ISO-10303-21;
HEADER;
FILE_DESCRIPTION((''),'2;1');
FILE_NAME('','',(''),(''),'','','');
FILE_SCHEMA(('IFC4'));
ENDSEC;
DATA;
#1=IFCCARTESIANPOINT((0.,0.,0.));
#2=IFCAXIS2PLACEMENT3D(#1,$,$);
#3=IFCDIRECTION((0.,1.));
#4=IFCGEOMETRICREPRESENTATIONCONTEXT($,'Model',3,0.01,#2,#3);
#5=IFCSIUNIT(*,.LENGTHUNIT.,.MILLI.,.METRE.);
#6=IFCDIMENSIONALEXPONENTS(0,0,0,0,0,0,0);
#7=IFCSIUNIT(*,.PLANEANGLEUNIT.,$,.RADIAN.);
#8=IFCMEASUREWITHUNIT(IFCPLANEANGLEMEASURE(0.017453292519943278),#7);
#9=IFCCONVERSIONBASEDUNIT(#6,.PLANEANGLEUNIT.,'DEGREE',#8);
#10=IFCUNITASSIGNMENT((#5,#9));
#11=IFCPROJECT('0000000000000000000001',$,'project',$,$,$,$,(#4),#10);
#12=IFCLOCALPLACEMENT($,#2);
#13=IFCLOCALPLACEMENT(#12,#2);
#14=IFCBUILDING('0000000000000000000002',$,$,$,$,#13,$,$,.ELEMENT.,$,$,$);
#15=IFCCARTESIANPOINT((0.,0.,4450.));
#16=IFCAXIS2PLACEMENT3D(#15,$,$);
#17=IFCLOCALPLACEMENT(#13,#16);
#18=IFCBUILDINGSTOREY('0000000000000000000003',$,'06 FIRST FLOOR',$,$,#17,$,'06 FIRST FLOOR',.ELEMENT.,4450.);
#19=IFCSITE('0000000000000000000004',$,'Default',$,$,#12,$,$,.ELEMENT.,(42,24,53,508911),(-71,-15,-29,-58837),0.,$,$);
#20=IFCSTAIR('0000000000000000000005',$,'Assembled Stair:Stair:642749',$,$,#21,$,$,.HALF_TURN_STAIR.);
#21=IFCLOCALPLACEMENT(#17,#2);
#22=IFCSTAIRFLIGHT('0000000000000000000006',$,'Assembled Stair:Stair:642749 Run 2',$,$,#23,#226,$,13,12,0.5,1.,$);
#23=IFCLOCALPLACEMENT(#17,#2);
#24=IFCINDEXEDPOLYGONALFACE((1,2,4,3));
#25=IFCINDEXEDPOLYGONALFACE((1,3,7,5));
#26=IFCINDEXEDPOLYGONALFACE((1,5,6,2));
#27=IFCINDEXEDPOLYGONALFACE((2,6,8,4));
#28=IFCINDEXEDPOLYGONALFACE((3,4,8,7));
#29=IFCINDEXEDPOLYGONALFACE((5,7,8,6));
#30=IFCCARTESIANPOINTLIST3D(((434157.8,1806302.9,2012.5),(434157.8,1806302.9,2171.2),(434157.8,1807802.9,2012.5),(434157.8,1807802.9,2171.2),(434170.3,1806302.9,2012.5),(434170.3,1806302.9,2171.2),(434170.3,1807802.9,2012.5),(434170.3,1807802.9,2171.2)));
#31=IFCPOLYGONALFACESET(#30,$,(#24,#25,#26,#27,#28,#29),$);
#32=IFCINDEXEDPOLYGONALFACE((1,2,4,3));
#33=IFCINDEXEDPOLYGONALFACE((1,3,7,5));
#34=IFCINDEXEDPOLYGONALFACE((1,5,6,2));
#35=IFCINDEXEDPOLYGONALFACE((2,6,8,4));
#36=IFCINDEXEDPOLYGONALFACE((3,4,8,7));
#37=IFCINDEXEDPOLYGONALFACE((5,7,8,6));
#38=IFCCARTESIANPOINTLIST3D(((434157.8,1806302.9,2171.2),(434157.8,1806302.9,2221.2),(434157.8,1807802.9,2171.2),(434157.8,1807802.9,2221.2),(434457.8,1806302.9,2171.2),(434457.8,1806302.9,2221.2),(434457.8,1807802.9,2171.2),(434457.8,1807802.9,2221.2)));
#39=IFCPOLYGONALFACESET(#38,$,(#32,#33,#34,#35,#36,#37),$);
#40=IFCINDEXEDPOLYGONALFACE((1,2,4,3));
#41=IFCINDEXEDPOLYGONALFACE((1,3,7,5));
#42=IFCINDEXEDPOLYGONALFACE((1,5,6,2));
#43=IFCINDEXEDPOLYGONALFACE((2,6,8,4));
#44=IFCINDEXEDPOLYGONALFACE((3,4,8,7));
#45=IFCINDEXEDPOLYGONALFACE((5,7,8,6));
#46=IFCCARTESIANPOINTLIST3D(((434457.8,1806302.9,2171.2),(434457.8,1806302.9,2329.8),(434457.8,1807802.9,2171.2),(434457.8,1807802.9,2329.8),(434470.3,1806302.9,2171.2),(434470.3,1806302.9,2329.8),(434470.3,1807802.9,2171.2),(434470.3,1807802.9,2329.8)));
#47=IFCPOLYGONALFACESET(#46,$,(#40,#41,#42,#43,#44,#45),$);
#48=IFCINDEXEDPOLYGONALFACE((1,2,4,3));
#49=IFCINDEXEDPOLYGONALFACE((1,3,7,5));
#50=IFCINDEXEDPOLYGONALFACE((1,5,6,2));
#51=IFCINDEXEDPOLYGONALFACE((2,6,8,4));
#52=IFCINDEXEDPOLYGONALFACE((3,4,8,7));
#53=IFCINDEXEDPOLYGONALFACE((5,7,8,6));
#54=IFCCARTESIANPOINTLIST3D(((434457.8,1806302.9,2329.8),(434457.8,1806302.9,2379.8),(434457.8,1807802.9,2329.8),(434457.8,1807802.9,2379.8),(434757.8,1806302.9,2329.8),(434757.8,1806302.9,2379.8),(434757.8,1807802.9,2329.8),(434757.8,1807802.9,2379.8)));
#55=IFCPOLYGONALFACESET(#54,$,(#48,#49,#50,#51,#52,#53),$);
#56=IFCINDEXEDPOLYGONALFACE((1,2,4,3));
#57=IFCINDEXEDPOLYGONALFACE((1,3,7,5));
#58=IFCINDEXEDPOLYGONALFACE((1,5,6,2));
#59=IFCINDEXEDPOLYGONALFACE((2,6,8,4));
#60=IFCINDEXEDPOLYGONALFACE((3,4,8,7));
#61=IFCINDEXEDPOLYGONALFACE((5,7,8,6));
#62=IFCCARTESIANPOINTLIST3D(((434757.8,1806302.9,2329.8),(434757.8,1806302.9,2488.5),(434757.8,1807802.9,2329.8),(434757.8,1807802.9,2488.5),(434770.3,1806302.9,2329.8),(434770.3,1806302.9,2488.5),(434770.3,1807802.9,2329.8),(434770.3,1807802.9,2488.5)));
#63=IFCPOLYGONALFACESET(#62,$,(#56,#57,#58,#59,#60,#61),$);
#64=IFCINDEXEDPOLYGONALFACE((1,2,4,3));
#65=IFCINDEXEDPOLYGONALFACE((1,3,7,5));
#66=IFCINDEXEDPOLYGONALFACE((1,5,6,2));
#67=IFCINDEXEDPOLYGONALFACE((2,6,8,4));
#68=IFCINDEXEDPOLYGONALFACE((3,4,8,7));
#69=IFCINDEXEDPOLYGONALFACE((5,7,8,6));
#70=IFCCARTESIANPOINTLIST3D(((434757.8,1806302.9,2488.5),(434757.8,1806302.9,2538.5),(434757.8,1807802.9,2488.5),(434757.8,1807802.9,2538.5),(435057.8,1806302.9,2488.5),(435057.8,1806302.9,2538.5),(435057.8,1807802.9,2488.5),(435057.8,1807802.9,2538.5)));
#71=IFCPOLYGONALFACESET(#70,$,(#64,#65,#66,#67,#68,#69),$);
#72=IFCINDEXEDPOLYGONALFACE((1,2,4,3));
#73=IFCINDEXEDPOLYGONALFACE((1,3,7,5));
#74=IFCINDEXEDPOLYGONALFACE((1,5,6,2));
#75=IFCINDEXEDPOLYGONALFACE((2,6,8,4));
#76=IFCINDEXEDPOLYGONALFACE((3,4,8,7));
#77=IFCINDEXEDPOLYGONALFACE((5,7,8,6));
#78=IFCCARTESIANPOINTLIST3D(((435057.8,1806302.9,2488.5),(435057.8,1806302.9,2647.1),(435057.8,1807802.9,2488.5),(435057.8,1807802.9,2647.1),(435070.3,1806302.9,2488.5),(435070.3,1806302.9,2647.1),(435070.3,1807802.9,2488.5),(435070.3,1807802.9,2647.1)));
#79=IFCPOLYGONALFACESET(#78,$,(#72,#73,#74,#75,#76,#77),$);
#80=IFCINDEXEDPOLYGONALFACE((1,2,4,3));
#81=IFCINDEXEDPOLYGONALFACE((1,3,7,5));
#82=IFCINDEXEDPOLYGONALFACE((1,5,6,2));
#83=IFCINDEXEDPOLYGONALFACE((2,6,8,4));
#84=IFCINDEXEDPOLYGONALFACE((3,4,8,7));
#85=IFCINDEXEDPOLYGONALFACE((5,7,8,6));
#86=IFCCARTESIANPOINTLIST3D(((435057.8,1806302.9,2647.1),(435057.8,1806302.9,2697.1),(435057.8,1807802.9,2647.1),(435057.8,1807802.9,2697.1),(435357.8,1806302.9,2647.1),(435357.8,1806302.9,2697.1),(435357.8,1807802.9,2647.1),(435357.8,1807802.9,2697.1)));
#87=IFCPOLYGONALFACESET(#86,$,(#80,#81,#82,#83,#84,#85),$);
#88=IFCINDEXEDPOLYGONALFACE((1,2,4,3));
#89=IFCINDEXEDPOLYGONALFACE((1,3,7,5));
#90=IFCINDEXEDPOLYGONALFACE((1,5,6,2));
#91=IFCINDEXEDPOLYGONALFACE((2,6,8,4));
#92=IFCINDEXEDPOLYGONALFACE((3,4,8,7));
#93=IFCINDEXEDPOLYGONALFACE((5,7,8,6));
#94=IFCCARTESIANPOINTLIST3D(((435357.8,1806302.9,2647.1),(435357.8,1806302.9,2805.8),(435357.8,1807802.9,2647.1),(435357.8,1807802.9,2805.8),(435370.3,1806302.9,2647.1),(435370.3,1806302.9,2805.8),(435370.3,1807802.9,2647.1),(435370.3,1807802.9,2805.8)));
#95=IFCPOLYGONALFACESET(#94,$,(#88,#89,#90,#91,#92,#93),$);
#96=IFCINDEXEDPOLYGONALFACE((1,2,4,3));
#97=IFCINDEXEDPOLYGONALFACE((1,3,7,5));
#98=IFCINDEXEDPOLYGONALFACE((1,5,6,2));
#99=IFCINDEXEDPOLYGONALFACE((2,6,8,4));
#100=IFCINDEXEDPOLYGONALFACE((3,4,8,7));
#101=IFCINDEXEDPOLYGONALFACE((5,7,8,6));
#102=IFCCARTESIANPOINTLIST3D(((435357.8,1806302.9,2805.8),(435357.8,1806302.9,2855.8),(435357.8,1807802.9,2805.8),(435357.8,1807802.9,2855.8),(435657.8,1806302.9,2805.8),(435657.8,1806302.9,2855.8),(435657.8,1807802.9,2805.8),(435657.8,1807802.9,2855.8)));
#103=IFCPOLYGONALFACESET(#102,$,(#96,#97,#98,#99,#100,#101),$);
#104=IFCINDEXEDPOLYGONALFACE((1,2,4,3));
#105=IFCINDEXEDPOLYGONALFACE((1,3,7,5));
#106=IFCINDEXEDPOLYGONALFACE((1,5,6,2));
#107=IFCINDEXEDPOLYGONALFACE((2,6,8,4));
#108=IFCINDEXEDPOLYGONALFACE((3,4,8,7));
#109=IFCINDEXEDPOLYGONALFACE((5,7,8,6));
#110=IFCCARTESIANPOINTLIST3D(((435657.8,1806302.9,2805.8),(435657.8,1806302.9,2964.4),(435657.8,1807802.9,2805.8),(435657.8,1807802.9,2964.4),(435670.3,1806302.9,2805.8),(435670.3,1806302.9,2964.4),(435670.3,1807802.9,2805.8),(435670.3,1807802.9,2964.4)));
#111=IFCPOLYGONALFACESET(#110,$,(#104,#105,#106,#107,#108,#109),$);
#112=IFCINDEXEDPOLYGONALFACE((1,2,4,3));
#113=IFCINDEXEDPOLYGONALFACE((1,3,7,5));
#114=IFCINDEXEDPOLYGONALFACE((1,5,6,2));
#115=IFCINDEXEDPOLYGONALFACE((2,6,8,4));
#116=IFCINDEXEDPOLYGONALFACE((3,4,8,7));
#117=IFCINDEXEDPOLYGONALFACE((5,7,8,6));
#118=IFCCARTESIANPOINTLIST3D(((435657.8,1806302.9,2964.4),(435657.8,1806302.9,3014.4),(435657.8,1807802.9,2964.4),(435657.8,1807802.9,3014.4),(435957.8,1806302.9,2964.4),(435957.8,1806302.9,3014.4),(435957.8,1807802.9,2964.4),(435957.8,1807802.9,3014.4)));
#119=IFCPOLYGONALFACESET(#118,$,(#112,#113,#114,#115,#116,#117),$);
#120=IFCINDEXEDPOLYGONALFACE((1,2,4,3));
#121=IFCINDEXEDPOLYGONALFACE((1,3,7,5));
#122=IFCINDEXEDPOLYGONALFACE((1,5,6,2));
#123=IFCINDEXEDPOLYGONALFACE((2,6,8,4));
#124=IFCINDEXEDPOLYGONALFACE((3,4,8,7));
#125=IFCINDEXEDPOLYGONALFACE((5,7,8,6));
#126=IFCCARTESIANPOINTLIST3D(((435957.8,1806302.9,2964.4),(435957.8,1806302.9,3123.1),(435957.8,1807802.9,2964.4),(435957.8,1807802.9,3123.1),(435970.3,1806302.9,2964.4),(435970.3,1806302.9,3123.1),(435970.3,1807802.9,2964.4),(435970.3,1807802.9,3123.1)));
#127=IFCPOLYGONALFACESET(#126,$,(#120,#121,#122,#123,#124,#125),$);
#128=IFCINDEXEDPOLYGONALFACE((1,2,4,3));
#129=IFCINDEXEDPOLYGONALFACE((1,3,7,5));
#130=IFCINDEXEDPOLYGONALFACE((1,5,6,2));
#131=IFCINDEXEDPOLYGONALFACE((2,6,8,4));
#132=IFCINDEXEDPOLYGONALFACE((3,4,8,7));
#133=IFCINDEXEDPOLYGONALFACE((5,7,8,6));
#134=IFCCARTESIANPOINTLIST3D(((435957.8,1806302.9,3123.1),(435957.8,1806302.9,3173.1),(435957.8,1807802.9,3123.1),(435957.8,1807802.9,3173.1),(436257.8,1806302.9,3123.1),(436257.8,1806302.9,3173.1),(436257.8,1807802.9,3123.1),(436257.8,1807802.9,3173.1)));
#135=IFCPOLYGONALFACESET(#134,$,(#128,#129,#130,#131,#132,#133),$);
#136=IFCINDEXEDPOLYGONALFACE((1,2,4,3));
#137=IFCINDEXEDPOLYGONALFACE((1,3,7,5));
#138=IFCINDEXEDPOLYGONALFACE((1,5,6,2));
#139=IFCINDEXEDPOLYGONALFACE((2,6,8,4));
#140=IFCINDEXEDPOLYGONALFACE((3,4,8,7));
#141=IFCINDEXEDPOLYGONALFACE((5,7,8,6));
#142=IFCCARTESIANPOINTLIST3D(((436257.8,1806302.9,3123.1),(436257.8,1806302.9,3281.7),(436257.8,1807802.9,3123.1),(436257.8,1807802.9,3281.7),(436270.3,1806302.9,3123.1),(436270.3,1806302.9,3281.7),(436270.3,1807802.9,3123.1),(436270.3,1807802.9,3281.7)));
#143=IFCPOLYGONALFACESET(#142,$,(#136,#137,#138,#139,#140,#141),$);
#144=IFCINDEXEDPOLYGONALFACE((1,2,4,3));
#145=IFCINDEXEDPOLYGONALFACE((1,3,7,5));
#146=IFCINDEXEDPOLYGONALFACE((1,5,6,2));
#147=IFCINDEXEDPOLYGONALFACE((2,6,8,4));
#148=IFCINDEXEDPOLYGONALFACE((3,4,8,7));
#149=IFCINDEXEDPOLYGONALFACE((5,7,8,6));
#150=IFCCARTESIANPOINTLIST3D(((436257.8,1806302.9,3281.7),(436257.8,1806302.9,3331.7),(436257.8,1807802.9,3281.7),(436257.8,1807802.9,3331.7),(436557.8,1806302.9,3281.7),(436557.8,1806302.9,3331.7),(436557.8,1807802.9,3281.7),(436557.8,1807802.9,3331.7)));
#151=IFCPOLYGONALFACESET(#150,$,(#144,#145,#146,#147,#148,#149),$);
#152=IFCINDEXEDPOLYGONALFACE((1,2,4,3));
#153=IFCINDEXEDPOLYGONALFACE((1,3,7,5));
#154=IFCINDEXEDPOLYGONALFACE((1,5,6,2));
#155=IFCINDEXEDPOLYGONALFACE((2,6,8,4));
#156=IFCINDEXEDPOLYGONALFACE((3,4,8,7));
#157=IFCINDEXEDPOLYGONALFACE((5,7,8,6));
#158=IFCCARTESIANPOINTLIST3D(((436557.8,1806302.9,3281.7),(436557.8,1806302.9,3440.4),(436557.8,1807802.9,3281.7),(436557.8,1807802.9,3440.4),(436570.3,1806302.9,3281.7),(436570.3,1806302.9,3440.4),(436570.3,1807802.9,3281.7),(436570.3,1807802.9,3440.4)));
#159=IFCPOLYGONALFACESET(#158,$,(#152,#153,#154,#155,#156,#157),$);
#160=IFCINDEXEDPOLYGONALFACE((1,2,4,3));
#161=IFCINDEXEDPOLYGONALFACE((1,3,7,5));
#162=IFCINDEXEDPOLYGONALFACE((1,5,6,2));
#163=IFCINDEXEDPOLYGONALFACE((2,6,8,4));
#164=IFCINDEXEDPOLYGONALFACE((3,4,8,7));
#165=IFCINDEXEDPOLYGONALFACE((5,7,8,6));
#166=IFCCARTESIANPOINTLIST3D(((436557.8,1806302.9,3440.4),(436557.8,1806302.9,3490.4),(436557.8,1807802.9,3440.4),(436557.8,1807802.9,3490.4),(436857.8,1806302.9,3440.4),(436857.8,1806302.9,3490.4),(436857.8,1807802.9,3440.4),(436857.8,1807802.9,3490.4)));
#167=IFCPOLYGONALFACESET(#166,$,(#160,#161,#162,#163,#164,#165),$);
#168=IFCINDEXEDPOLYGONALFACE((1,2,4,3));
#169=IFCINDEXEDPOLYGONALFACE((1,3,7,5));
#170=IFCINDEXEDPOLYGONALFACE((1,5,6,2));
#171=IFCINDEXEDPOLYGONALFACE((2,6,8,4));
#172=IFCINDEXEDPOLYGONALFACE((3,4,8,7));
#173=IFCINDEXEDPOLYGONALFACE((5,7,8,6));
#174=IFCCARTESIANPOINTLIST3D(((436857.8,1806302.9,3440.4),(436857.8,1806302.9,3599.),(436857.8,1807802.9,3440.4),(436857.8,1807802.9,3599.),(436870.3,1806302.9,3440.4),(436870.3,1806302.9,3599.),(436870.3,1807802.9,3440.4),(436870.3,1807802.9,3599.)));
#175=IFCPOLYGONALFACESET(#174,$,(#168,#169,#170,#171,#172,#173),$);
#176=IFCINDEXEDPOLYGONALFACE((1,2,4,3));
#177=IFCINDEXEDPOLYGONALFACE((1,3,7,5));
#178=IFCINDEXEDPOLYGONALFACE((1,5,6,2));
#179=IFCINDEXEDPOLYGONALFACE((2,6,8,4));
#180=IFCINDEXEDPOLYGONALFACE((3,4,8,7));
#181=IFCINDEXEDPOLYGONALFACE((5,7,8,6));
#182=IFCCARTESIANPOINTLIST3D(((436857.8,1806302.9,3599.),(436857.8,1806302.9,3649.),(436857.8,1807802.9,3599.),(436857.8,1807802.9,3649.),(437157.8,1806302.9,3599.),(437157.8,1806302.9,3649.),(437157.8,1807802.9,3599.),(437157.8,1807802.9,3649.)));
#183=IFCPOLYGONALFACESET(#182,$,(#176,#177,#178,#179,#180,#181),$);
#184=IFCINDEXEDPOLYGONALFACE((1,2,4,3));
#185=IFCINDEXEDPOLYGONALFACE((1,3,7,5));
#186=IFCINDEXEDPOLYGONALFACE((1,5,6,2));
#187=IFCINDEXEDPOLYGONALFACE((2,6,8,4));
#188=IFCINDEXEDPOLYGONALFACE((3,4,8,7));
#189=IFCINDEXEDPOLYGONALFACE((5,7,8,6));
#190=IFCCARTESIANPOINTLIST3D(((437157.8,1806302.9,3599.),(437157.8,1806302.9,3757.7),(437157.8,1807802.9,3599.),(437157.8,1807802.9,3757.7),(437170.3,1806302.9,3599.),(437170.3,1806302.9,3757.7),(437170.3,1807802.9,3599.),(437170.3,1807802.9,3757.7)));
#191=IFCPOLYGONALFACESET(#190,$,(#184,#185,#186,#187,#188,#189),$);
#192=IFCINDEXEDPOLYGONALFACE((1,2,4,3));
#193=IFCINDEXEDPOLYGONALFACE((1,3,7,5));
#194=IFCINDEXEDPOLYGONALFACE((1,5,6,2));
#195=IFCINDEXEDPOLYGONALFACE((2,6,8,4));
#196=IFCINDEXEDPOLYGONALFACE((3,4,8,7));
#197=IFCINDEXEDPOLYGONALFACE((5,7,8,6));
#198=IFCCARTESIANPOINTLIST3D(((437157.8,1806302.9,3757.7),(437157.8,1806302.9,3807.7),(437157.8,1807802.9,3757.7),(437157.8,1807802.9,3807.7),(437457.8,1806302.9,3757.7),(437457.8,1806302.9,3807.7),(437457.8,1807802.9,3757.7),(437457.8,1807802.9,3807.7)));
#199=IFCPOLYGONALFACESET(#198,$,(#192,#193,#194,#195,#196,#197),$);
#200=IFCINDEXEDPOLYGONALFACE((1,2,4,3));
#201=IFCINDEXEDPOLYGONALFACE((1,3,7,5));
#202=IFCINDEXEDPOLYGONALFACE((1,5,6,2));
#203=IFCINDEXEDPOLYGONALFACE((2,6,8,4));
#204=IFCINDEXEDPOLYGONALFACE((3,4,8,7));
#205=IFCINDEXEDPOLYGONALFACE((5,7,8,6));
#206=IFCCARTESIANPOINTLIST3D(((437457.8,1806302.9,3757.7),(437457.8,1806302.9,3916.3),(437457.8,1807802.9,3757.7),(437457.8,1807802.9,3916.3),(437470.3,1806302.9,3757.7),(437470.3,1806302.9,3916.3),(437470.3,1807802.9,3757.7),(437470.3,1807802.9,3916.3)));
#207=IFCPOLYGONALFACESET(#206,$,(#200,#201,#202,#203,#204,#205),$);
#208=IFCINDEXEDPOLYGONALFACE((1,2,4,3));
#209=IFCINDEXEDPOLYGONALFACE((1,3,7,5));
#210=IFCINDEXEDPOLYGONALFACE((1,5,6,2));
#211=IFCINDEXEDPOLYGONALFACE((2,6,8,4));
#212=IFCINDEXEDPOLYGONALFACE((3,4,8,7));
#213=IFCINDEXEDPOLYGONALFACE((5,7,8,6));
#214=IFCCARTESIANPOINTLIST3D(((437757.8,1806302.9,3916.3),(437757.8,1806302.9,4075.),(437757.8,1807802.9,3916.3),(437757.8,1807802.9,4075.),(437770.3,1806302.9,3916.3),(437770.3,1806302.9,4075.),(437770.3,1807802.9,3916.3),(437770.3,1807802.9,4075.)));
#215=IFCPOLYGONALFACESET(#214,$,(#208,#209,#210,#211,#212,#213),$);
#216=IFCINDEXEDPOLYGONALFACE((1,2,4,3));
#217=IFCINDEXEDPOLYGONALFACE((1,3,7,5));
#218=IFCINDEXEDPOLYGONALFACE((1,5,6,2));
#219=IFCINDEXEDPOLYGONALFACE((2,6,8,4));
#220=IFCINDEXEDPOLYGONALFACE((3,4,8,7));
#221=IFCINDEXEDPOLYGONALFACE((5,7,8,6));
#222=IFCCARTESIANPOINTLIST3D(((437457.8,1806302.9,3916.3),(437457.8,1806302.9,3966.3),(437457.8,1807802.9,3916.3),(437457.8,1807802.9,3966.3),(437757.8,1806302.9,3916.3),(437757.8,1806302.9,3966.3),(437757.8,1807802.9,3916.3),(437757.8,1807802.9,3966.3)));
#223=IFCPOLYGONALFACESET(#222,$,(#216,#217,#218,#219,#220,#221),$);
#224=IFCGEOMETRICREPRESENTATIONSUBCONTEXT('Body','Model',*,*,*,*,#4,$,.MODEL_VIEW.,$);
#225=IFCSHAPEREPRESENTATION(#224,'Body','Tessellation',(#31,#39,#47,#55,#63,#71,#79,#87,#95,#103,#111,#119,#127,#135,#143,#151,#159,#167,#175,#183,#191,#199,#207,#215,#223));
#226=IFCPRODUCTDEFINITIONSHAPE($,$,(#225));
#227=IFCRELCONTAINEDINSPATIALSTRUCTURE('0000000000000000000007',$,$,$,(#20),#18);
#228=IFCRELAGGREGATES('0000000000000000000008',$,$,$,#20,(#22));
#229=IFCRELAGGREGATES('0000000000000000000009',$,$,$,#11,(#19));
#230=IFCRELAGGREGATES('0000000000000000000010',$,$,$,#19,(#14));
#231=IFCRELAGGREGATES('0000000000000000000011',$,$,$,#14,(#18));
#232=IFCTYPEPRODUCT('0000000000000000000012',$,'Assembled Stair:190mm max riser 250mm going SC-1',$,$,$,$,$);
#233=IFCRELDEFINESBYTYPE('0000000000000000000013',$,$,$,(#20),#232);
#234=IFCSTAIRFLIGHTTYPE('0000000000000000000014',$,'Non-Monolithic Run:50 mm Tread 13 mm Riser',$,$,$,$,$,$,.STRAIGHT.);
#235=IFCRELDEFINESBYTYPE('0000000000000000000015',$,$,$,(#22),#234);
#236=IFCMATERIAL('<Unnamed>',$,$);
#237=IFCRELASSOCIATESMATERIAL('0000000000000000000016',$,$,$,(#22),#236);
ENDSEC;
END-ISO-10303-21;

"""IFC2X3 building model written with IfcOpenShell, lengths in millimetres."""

from ifc_helpers import new_model, entity, si_unit, converted_unit, direction, frame, origin, origin_2d_with_axis, place, context, subcontext, project, spatial, rectangle, extrude, material, type_object, element, aggregate, save


model = new_model("IFC2X3")

# Units and contexts
model_context = context("Model", 3, precision=0.01, world=origin(), true_north=direction((0.0, 1.0)))
body_context = subcontext(model_context, "Body", "Model", "MODEL_VIEW")
ifc_project = project(units=[si_unit("LENGTHUNIT", "METRE", prefix="MILLI"), converted_unit("PLANEANGLEUNIT", "DEGREE", entity("IfcPlaneAngleMeasure", 0.017453292519943278), si_unit("PLANEANGLEUNIT", "RADIAN"), dimensions=[0, 0, 0, 0, 0, 0, 0])], contexts=[model_context])

# Site, building, storey
site_placement = place(None, origin())
site = spatial("IfcSite", under=ifc_project, at=site_placement, Name="Default", CompositionType="ELEMENT", RefLatitude=(42, 24, 53, 508911), RefLongitude=(-71, -15, -29, -58837), RefElevation=0.0)
building_placement = place(site_placement, origin())
building = spatial("IfcBuilding", under=site, at=building_placement, CompositionType="ELEMENT")
storey_placement = place(building_placement, frame((0.0, 0.0, 4450.0)))
storey = spatial("IfcBuildingStorey", under=building, at=storey_placement, Name="06 FIRST FLOOR", LongName="06 FIRST FLOOR", CompositionType="ELEMENT", Elevation=4450.0)

# Stair
type_product_1 = type_object("IfcTypeProduct", Name="Assembled Stair:190mm max riser 250mm going SC-1")
stair_1_placement = place(storey_placement, origin())
stair_1 = element("IfcStair", 1, at=stair_1_placement, inside=storey, type_object=type_product_1, Name="Assembled Stair:Stair:642749", ShapeType="HALF_TURN_STAIR")
ifc_material_1 = material(Name="<Unnamed>")

# Stair flight
stair_flight_type = type_object("IfcStairFlightType", Name="Non-Monolithic Run:50 mm Tread 13 mm Riser", PredefinedType="STRAIGHT")
stair_flight_1_placement = place(stair_1_placement, origin())
stair_flight_1 = element("IfcStairFlight", 2, at=stair_flight_1_placement, type_object=stair_flight_type, material=ifc_material_1, Name="Assembled Stair:Stair:642749 Run 2", NumberOfRiser=13, NumberOfTreads=12, RiserHeight=0.5, TreadLength=1.0, context=body_context, shape_type="SweptSolid", body=[
    extrude(rectangle(XDim=1500.0, YDim=12.5, at=origin_2d_with_axis()), frame((434164.0, 1807052.9, 2012.5), z_axis=(0.0, 0.0, 1.0), x_axis=(0.0, 1.0, 0.0)), (0.0, 0.0, 1.0), 158.7),
    extrude(rectangle(XDim=300.0, YDim=1500.0, at=origin_2d_with_axis()), frame((434307.8, 1807052.9, 2171.2), z_axis=(0.0, 0.0, 1.0), x_axis=(-1.0, 0.0, 0.0)), (0.0, 0.0, 1.0), 50.0),
    extrude(rectangle(XDim=1500.0, YDim=12.5, at=origin_2d_with_axis()), frame((434464.0, 1807052.9, 2171.2), z_axis=(0.0, 0.0, 1.0), x_axis=(0.0, 1.0, 0.0)), (0.0, 0.0, 1.0), 158.7),
    extrude(rectangle(XDim=300.0, YDim=1500.0, at=origin_2d_with_axis()), frame((434607.8, 1807052.9, 2329.8), z_axis=(0.0, 0.0, 1.0), x_axis=(-1.0, 0.0, 0.0)), (0.0, 0.0, 1.0), 50.0),
    extrude(rectangle(XDim=1500.0, YDim=12.5, at=origin_2d_with_axis()), frame((434764.0, 1807052.9, 2329.8), z_axis=(0.0, 0.0, 1.0), x_axis=(0.0, 1.0, 0.0)), (0.0, 0.0, 1.0), 158.7),
    extrude(rectangle(XDim=300.0, YDim=1500.0, at=origin_2d_with_axis()), frame((434907.8, 1807052.9, 2488.5), z_axis=(0.0, 0.0, 1.0), x_axis=(-1.0, 0.0, 0.0)), (0.0, 0.0, 1.0), 50.0),
    extrude(rectangle(XDim=1500.0, YDim=12.5, at=origin_2d_with_axis()), frame((435064.0, 1807052.9, 2488.5), z_axis=(0.0, 0.0, 1.0), x_axis=(0.0, 1.0, 0.0)), (0.0, 0.0, 1.0), 158.7),
    extrude(rectangle(XDim=300.0, YDim=1500.0, at=origin_2d_with_axis()), frame((435207.8, 1807052.9, 2647.1), z_axis=(0.0, 0.0, 1.0), x_axis=(-1.0, 0.0, 0.0)), (0.0, 0.0, 1.0), 50.0),
    extrude(rectangle(XDim=1500.0, YDim=12.5, at=origin_2d_with_axis()), frame((435364.0, 1807052.9, 2647.1), z_axis=(0.0, 0.0, 1.0), x_axis=(0.0, 1.0, 0.0)), (0.0, 0.0, 1.0), 158.7),
    extrude(rectangle(XDim=300.0, YDim=1500.0, at=origin_2d_with_axis()), frame((435507.8, 1807052.9, 2805.8), z_axis=(0.0, 0.0, 1.0), x_axis=(-1.0, 0.0, 0.0)), (0.0, 0.0, 1.0), 50.0),
    extrude(rectangle(XDim=1500.0, YDim=12.5, at=origin_2d_with_axis()), frame((435664.0, 1807052.9, 2805.8), z_axis=(0.0, 0.0, 1.0), x_axis=(0.0, 1.0, 0.0)), (0.0, 0.0, 1.0), 158.7),
    extrude(rectangle(XDim=300.0, YDim=1500.0, at=origin_2d_with_axis()), frame((435807.8, 1807052.9, 2964.4), z_axis=(0.0, 0.0, 1.0), x_axis=(-1.0, 0.0, 0.0)), (0.0, 0.0, 1.0), 50.0),
    extrude(rectangle(XDim=1500.0, YDim=12.5, at=origin_2d_with_axis()), frame((435964.0, 1807052.9, 2964.4), z_axis=(0.0, 0.0, 1.0), x_axis=(0.0, 1.0, 0.0)), (0.0, 0.0, 1.0), 158.7),
    extrude(rectangle(XDim=300.0, YDim=1500.0, at=origin_2d_with_axis()), frame((436107.8, 1807052.9, 3123.1), z_axis=(0.0, 0.0, 1.0), x_axis=(-1.0, 0.0, 0.0)), (0.0, 0.0, 1.0), 50.0),
    extrude(rectangle(XDim=1500.0, YDim=12.5, at=origin_2d_with_axis()), frame((436264.0, 1807052.9, 3123.1), z_axis=(0.0, 0.0, 1.0), x_axis=(0.0, 1.0, 0.0)), (0.0, 0.0, 1.0), 158.7),
    extrude(rectangle(XDim=300.0, YDim=1500.0, at=origin_2d_with_axis()), frame((436407.8, 1807052.9, 3281.7), z_axis=(0.0, 0.0, 1.0), x_axis=(-1.0, 0.0, 0.0)), (0.0, 0.0, 1.0), 50.0),
    extrude(rectangle(XDim=1500.0, YDim=12.5, at=origin_2d_with_axis()), frame((436564.0, 1807052.9, 3281.7), z_axis=(0.0, 0.0, 1.0), x_axis=(0.0, 1.0, 0.0)), (0.0, 0.0, 1.0), 158.7),
    extrude(rectangle(XDim=300.0, YDim=1500.0, at=origin_2d_with_axis()), frame((436707.8, 1807052.9, 3440.4), z_axis=(0.0, 0.0, 1.0), x_axis=(-1.0, 0.0, 0.0)), (0.0, 0.0, 1.0), 50.0),
    extrude(rectangle(XDim=1500.0, YDim=12.5, at=origin_2d_with_axis()), frame((436864.0, 1807052.9, 3440.4), z_axis=(0.0, 0.0, 1.0), x_axis=(0.0, 1.0, 0.0)), (0.0, 0.0, 1.0), 158.7),
    extrude(rectangle(XDim=300.0, YDim=1500.0, at=origin_2d_with_axis()), frame((437007.8, 1807052.9, 3599.0), z_axis=(0.0, 0.0, 1.0), x_axis=(-1.0, 0.0, 0.0)), (0.0, 0.0, 1.0), 50.0),
    extrude(rectangle(XDim=1500.0, YDim=12.5, at=origin_2d_with_axis()), frame((437164.0, 1807052.9, 3599.0), z_axis=(0.0, 0.0, 1.0), x_axis=(0.0, 1.0, 0.0)), (0.0, 0.0, 1.0), 158.7),
    extrude(rectangle(XDim=300.0, YDim=1500.0, at=origin_2d_with_axis()), frame((437307.8, 1807052.9, 3757.7), z_axis=(0.0, 0.0, 1.0), x_axis=(-1.0, 0.0, 0.0)), (0.0, 0.0, 1.0), 50.0),
    extrude(rectangle(XDim=1500.0, YDim=12.5, at=origin_2d_with_axis()), frame((437464.0, 1807052.9, 3757.7), z_axis=(0.0, 0.0, 1.0), x_axis=(0.0, 1.0, 0.0)), (0.0, 0.0, 1.0), 158.7),
    extrude(rectangle(XDim=1500.0, YDim=12.5, at=origin_2d_with_axis()), frame((437764.0, 1807052.9, 3916.3), z_axis=(0.0, 0.0, 1.0), x_axis=(0.0, 1.0, 0.0)), (0.0, 0.0, 1.0), 158.7),
    extrude(rectangle(XDim=300.0, YDim=1500.0, at=origin_2d_with_axis()), frame((437607.8, 1807052.9, 3916.3), z_axis=(0.0, 0.0, 1.0), x_axis=(-1.0, 0.0, 0.0)), (0.0, 0.0, 1.0), 50.0),
])
aggregate(stair_1, [stair_flight_1])

save(model, "model.ifc")
